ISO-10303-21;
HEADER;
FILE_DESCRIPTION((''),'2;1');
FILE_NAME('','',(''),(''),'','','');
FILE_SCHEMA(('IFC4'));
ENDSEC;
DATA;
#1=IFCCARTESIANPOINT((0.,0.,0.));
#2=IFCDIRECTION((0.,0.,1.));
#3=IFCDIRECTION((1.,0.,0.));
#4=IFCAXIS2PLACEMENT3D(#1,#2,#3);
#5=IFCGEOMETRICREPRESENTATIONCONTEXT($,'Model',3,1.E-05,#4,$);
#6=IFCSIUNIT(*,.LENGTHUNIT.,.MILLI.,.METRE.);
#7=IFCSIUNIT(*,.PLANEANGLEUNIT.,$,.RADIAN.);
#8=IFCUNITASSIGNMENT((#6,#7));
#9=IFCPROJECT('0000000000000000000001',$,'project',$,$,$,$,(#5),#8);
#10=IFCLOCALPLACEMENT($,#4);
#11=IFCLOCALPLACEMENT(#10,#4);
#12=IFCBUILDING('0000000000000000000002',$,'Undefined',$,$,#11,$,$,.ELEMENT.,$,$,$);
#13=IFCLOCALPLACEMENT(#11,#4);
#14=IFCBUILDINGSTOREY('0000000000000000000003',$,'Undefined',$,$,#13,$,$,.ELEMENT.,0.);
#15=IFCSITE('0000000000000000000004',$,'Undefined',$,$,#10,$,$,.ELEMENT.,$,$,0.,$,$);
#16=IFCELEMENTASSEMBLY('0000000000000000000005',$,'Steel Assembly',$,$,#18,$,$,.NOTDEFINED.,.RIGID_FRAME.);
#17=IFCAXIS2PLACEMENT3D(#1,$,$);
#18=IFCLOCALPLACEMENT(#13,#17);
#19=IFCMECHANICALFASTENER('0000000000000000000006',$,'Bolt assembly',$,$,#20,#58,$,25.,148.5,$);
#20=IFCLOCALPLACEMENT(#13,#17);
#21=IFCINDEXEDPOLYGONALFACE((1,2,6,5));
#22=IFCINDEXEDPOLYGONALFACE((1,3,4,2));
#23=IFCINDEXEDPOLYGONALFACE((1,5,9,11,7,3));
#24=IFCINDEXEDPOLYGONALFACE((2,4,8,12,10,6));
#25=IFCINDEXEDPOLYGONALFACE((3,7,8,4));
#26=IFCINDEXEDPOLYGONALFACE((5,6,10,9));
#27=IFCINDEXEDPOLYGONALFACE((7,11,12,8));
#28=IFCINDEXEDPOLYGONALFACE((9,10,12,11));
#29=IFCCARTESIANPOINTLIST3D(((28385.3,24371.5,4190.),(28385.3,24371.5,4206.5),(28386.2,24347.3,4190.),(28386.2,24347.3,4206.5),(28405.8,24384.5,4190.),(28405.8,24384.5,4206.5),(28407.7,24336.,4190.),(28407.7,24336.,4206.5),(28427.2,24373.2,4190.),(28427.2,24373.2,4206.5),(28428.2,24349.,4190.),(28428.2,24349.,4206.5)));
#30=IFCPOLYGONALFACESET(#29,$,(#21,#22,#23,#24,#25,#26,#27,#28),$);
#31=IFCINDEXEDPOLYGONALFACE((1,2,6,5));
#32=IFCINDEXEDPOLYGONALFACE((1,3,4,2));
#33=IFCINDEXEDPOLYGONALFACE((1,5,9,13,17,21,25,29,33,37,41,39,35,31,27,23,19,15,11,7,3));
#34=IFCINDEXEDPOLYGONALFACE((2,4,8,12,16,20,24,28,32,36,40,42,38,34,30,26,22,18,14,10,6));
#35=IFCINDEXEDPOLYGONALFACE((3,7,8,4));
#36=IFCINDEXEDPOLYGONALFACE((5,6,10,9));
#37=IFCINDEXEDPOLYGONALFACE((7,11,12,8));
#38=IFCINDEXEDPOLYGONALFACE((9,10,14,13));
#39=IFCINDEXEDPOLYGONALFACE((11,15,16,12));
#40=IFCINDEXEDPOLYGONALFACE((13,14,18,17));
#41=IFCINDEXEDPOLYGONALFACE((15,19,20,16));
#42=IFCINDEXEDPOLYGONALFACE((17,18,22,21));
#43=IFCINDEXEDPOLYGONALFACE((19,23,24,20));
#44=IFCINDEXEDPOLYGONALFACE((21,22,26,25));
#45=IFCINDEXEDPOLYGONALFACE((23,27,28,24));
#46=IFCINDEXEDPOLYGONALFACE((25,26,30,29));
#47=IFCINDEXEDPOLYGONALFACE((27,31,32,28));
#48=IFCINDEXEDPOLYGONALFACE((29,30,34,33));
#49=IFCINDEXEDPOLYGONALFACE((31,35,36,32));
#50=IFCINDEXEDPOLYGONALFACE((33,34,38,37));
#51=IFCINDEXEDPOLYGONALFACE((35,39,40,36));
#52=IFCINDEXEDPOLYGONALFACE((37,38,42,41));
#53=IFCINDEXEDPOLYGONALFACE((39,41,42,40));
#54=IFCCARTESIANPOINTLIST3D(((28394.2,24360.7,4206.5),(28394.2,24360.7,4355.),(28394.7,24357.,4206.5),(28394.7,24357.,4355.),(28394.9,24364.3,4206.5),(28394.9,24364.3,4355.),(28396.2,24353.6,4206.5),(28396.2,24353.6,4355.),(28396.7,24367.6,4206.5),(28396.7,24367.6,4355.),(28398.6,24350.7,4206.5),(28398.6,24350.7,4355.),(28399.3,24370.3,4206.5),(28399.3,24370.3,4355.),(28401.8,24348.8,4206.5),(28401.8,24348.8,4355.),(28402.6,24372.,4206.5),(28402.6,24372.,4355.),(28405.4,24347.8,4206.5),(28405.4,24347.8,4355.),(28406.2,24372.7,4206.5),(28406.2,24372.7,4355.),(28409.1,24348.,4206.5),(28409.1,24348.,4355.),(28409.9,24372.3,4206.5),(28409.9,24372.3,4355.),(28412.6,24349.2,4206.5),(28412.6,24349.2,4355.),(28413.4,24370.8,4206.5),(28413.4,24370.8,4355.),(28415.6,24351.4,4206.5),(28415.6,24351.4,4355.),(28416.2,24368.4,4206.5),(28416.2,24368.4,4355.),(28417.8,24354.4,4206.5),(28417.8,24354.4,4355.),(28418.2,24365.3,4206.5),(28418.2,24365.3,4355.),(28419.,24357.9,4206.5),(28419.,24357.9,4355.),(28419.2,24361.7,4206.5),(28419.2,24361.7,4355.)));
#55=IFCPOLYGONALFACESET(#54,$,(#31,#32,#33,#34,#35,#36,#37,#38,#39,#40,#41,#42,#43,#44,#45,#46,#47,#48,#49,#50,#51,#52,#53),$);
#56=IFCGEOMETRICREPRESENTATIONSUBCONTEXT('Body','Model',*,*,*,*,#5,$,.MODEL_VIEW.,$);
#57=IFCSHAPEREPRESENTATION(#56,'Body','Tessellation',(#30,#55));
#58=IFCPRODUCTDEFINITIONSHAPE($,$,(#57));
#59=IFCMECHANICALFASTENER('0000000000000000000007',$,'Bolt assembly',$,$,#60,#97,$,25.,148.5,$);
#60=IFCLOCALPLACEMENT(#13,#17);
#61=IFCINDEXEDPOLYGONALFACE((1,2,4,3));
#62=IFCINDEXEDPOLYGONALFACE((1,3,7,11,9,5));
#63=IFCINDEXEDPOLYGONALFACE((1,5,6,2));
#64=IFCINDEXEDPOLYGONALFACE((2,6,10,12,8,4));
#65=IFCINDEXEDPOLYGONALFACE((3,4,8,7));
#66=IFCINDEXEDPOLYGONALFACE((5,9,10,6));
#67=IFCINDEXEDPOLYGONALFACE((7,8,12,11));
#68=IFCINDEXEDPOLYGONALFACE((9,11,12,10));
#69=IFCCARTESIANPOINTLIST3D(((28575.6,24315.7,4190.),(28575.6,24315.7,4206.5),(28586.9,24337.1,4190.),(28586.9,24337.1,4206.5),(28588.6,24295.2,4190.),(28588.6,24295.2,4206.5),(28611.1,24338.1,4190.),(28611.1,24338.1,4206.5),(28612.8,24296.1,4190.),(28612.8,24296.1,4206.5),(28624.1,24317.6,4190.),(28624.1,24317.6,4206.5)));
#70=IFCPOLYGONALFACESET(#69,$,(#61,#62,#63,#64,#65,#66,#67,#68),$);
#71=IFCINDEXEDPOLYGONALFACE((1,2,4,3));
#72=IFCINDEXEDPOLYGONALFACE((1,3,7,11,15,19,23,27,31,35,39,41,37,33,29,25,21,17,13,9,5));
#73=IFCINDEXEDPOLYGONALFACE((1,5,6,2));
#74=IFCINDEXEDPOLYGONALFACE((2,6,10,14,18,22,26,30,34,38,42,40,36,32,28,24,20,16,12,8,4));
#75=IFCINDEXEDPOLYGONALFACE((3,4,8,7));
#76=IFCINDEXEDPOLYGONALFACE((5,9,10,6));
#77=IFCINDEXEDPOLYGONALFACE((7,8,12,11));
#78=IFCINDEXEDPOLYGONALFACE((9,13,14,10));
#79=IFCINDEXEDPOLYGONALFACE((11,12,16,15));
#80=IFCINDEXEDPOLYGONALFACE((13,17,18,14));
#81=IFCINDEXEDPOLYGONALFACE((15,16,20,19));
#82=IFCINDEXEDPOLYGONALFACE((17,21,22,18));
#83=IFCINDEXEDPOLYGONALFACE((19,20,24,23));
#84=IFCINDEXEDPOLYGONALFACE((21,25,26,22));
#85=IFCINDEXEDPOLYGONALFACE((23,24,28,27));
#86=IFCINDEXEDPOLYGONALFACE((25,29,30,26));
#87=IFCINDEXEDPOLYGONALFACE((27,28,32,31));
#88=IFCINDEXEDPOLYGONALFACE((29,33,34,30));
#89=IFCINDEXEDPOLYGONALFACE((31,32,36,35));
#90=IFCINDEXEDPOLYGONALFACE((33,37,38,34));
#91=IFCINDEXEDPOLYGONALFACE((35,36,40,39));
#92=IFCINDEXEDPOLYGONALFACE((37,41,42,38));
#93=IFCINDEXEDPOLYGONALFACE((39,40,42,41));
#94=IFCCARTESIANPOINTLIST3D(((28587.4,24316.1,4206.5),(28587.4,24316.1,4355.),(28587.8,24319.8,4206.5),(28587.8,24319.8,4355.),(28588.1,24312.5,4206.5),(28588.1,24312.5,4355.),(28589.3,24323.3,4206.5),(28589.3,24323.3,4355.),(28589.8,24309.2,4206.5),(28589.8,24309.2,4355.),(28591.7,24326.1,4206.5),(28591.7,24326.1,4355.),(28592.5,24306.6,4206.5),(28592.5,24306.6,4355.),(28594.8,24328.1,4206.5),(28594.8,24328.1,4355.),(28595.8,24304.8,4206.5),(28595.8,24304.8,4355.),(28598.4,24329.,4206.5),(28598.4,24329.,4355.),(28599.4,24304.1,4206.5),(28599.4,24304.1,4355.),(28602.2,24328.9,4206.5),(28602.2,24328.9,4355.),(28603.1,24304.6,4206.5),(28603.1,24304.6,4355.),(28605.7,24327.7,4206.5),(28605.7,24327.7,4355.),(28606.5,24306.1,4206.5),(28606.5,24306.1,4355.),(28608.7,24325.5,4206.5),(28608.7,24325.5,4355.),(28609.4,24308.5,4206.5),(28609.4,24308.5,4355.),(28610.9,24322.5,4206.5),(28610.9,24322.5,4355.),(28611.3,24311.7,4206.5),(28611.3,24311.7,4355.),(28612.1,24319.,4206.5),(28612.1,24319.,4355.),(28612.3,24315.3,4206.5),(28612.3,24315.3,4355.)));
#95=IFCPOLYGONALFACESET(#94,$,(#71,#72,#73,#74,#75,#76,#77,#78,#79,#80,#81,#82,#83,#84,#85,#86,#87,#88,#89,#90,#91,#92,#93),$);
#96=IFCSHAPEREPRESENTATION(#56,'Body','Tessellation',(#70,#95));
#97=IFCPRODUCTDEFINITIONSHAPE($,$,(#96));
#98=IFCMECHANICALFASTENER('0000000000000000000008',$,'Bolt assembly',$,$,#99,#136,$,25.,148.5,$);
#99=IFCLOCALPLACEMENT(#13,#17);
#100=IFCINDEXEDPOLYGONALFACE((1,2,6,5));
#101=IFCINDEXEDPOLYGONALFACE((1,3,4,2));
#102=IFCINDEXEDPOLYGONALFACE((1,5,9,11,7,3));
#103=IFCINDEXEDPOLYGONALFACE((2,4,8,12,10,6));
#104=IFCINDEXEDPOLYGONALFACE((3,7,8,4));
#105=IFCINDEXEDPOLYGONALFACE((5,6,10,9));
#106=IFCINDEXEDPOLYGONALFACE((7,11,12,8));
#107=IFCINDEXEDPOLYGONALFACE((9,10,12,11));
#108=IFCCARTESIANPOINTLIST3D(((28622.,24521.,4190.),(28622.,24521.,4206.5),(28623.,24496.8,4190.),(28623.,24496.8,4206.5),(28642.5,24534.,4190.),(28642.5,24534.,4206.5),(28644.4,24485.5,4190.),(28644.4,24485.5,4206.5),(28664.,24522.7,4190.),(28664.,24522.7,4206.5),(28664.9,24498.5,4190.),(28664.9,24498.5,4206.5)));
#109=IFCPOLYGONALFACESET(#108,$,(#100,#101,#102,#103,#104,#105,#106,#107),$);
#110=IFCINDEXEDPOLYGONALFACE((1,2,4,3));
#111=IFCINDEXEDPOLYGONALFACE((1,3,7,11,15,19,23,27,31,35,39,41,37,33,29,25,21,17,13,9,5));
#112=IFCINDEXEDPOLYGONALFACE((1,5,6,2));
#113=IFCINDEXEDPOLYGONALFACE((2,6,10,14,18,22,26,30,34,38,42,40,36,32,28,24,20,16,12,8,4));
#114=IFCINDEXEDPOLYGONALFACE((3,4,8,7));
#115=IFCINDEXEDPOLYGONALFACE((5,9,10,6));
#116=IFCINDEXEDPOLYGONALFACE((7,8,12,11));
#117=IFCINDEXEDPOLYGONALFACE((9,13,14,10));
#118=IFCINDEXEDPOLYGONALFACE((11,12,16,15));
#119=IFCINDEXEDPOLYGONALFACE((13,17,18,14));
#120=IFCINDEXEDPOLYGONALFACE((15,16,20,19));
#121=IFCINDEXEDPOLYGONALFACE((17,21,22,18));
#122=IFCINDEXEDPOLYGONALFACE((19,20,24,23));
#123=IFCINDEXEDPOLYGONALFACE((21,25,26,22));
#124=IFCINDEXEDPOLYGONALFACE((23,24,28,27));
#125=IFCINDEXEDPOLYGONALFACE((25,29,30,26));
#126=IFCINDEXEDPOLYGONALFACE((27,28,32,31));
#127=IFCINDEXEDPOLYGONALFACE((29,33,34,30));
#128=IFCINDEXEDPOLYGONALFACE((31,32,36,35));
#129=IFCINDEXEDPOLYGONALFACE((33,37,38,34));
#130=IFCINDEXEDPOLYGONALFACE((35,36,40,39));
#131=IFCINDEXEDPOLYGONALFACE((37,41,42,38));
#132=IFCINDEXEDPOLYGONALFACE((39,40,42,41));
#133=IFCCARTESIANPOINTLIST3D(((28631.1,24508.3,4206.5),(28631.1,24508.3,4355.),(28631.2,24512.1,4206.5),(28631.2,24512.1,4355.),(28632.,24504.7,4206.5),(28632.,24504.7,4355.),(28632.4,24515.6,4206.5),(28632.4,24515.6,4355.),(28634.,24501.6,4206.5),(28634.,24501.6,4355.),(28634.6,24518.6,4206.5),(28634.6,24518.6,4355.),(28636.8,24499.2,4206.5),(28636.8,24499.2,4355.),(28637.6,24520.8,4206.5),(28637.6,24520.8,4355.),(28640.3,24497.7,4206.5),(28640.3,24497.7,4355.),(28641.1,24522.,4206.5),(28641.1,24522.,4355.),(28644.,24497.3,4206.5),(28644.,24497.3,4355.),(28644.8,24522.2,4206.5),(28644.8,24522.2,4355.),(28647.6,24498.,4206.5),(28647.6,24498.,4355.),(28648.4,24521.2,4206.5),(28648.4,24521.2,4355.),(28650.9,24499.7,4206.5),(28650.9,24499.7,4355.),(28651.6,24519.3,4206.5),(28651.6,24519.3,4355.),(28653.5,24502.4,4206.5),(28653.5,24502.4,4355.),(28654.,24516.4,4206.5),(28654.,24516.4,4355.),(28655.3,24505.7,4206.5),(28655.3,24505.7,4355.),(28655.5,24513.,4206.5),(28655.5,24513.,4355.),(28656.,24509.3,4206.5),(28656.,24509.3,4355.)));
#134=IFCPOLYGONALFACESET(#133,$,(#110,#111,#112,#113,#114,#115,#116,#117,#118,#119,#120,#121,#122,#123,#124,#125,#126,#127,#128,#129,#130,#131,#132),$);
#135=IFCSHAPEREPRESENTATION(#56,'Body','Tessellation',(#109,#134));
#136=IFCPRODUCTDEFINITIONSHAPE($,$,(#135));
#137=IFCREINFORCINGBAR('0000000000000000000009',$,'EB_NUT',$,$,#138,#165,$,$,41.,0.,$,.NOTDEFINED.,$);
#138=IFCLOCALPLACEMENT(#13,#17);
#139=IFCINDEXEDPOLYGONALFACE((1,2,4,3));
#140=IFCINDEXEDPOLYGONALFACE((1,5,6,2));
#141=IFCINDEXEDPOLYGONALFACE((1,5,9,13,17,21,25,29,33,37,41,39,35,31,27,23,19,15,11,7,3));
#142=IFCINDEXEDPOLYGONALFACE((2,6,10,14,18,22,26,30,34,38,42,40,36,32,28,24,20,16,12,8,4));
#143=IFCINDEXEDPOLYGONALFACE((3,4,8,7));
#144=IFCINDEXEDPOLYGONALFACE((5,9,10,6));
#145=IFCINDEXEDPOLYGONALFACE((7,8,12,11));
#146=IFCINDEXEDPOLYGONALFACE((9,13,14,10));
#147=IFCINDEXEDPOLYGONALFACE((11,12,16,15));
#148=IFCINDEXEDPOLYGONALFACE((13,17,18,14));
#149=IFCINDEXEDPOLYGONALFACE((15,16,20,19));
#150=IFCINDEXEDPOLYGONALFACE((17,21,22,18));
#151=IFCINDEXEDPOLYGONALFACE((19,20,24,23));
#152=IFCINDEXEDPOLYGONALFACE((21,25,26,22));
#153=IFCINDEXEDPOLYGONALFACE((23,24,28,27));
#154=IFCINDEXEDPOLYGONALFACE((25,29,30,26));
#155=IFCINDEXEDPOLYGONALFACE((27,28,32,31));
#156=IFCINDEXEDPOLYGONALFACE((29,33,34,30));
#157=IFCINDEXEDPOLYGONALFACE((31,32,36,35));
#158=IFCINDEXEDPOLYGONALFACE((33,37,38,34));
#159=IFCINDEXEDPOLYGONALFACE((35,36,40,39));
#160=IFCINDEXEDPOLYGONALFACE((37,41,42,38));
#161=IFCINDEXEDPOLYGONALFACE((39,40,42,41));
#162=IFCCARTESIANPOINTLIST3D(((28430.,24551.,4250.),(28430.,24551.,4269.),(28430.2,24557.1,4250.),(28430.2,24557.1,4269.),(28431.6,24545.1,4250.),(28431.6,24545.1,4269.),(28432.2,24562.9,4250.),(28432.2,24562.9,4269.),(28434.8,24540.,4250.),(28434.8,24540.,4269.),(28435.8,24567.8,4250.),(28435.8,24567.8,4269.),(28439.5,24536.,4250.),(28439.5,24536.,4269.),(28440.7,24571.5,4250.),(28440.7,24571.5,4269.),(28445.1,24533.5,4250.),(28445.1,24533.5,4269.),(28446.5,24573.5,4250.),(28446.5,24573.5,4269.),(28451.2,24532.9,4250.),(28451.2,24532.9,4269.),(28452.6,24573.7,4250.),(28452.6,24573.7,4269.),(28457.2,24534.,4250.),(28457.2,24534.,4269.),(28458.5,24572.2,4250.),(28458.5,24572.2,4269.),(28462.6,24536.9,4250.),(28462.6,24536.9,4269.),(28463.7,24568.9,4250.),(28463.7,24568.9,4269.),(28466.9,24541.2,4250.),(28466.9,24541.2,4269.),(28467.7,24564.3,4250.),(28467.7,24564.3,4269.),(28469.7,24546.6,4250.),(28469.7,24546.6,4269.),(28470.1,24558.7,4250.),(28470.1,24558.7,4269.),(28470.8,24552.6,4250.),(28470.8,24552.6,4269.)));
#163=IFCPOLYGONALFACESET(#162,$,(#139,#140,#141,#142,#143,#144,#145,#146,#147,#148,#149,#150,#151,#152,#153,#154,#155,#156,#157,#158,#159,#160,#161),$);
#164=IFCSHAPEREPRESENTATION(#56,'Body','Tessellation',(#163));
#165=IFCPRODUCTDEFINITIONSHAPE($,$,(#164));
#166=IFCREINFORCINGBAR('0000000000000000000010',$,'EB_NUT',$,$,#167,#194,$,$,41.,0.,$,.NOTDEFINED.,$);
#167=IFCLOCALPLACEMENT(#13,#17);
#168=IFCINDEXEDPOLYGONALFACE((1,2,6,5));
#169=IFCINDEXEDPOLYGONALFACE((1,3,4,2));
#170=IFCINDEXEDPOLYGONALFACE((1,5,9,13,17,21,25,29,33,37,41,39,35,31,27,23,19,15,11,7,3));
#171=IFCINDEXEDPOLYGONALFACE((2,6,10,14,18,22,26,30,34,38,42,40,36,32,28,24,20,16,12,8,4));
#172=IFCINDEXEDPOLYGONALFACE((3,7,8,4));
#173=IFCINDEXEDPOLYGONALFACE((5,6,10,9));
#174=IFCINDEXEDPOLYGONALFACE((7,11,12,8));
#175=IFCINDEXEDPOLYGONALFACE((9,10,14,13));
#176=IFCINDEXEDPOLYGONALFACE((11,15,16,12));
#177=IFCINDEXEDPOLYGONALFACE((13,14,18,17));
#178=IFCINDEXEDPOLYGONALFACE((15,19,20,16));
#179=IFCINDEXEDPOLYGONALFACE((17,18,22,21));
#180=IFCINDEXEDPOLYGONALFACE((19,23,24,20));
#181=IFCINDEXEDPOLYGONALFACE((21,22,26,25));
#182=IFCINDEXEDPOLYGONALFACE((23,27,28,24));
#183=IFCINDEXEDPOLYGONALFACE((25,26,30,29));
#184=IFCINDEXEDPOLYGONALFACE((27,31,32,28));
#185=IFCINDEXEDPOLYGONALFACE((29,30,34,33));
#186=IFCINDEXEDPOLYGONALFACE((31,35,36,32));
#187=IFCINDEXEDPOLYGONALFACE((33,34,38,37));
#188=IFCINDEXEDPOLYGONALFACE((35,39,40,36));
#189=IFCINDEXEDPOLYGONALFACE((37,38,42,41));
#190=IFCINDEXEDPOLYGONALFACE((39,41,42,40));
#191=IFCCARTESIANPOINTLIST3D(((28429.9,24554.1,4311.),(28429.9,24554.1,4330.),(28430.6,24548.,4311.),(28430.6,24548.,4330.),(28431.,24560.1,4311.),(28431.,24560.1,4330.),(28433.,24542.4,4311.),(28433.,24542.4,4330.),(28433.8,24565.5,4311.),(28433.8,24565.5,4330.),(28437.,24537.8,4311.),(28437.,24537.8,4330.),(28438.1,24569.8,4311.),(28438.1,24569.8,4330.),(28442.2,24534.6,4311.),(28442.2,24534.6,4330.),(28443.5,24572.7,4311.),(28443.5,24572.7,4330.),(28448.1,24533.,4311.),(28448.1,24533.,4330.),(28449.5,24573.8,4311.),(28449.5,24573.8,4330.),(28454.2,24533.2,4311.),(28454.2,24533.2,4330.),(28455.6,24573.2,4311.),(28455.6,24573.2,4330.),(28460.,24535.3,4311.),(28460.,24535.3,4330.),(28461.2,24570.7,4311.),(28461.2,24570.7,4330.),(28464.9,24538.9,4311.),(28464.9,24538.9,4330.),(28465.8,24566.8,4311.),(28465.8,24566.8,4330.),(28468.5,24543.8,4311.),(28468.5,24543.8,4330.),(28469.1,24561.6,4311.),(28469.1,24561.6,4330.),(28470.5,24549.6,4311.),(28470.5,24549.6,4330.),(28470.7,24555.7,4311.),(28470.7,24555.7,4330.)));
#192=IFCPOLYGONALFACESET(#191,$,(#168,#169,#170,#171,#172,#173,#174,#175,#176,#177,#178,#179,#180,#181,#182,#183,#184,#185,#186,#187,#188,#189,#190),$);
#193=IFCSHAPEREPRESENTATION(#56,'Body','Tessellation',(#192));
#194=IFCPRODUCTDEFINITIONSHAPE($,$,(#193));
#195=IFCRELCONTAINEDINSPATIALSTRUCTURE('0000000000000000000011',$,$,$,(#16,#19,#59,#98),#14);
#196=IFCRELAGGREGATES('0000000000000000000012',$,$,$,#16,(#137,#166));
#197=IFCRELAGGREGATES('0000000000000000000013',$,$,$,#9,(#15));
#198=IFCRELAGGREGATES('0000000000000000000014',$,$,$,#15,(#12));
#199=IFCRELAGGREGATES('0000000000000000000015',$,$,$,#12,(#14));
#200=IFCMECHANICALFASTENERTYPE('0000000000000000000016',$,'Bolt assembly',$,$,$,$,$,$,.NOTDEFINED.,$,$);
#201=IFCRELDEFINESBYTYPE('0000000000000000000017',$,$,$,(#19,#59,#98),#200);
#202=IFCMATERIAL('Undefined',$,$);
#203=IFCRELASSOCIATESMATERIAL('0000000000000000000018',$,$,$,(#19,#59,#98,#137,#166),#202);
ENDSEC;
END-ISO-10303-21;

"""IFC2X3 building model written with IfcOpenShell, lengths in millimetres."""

from ifc_helpers import new_model, entity, si_unit, frame, origin_with_axes, origin_2d_with_axis, place, context, subcontext, project, spatial, polyline, circle, outline, extrude, source, transform, mapped, material, type_object, element, aggregate, save


model = new_model("IFC2X3")

# Units and contexts
model_context = context("Model", 3, precision=1e-05, world=origin_with_axes())
body_context = subcontext(model_context, "Body", "Model", "MODEL_VIEW")
ifc_project = project(units=[si_unit("LENGTHUNIT", "METRE", prefix="MILLI"), si_unit("PLANEANGLEUNIT", "RADIAN")], contexts=[model_context])

# Site, building, storey
site_placement = place(None, origin_with_axes())
site = spatial("IfcSite", under=ifc_project, at=site_placement, Name="Undefined", CompositionType="ELEMENT", RefElevation=0.0)
building_placement = place(site_placement, origin_with_axes())
building = spatial("IfcBuilding", under=site, at=building_placement, Name="Undefined", CompositionType="ELEMENT")
storey_placement = place(building_placement, origin_with_axes())
storey = spatial("IfcBuildingStorey", under=building, at=storey_placement, Name="Undefined", CompositionType="ELEMENT", Elevation=0.0)

# Element assembly
assembly_1_placement = place(storey_placement, origin_with_axes())
assembly_1 = element("IfcElementAssembly", 1, at=assembly_1_placement, inside=storey, Name="Steel Assembly", AssemblyPlace="NOTDEFINED", PredefinedType="RIGID_FRAME")

# Mechanical fasteners
ifc_material_1 = material(Name="Undefined")
mechanical_fastener_type = type_object("IfcMechanicalFastenerType", Name="Bolt assembly")
shared_shape_1 = source(origin_with_axes(), body_context, "Body", "SweptSolid", [
    extrude(outline(polyline([(24.2, 0.0), (12.1, 21.0), (-12.1, 21.0), (-24.2, 0.0), (-12.1, -21.0), (12.1, -21.0), (24.2, 0.0)])), frame((0.0, -165.0, 0.0), z_axis=(0.0, 1.0, 0.0), x_axis=(1.0, 0.0, 0.0)), (0.0, 0.0, 1.0), 16.5),
    extrude(circle(Radius=12.5, at=origin_2d_with_axis()), frame((0.0, -148.5, 0.0), z_axis=(0.0, 1.0, 0.0), x_axis=(1.0, 0.0, 0.0)), (0.0, 0.0, 1.0), 148.5),
])
for number, where, z_axis, x_axis, name in (
    (2, (28406.7, 24360.2, 4355.0), (-0.534023, 0.84547, 0.0), (-0.84547, -0.534023, 0.0), "Bolt assembly"),
    (3, (28599.9, 24316.6, 4355.0), (-0.84547, -0.534023, 0.0), (0.534023, -0.84547, 0.0), "Bolt assembly"),
    (4, (28643.5, 24509.8, 4355.0), (0.534023, -0.84547, 0.0), (0.84547, 0.534023, 0.0), "Bolt assembly"),
):
    element("IfcMechanicalFastener", number, at=place(storey_placement, frame(where, z_axis=z_axis, x_axis=x_axis)), inside=storey, type_object=mechanical_fastener_type, material=ifc_material_1, Name=name, NominalDiameter=25.0, NominalLength=148.5, context=body_context, shape_type="MappedRepresentation", body=[
        mapped(shared_shape_1, transform((0.0, 0.0, 0.0))),
    ])

# Reinforcing bars
shared_shape_2 = source(origin_with_axes(), body_context, "Body", "AdvancedSweptSolid", [
    entity("IfcSweptDiskSolid", entity("IfcTrimmedCurve", entity("IfcLine", entity("IfcCartesianPoint", [0.0, 0.0, 0.0]), entity("IfcVector", entity("IfcDirection", [1.0, 0.0, 0.0]), 1.0)), [entity("IfcParameterValue", 0.0)], [entity("IfcParameterValue", 19.0)], True, "PARAMETER"), 20.5, None, 0.0, 19.0),
])
reinforcing_bar_1_placement = place(assembly_1_placement, frame((28450.3, 24553.4, 4250.0), z_axis=(0.84547, 0.534023, 0.0), x_axis=(0.0, 0.0, 1.0)))
reinforcing_bar_1 = element("IfcReinforcingBar", 5, at=reinforcing_bar_1_placement, material=ifc_material_1, Name="EB_NUT", BarRole="NOTDEFINED", CrossSectionArea=0.0, NominalDiameter=41.0, context=body_context, shape_type="MappedRepresentation", body=[
    mapped(shared_shape_2, transform((0.0, 0.0, 0.0))),
])
shared_shape_3 = source(origin_with_axes(), body_context, "Body", "AdvancedSweptSolid", [
    entity("IfcSweptDiskSolid", entity("IfcTrimmedCurve", entity("IfcLine", entity("IfcCartesianPoint", [0.0, 0.0, 0.0]), entity("IfcVector", entity("IfcDirection", [1.0, 0.0, 0.0]), 1.0)), [entity("IfcParameterValue", 0.0)], [entity("IfcParameterValue", 19.0)], True, "PARAMETER"), 20.5, None, 0.0, 19.0),
])
reinforcing_bar_2_placement = place(assembly_1_placement, frame((28450.3, 24553.4, 4330.0), z_axis=(-0.84547, -0.534023, 0.0), x_axis=(0.0, 0.0, -1.0)))
reinforcing_bar_2 = element("IfcReinforcingBar", 6, at=reinforcing_bar_2_placement, material=ifc_material_1, Name="EB_NUT", BarRole="NOTDEFINED", CrossSectionArea=0.0, NominalDiameter=41.0, context=body_context, shape_type="MappedRepresentation", body=[
    mapped(shared_shape_3, transform((0.0, 0.0, 0.0))),
])
aggregate(assembly_1, [reinforcing_bar_1, reinforcing_bar_2])

save(model, "model.ifc")
